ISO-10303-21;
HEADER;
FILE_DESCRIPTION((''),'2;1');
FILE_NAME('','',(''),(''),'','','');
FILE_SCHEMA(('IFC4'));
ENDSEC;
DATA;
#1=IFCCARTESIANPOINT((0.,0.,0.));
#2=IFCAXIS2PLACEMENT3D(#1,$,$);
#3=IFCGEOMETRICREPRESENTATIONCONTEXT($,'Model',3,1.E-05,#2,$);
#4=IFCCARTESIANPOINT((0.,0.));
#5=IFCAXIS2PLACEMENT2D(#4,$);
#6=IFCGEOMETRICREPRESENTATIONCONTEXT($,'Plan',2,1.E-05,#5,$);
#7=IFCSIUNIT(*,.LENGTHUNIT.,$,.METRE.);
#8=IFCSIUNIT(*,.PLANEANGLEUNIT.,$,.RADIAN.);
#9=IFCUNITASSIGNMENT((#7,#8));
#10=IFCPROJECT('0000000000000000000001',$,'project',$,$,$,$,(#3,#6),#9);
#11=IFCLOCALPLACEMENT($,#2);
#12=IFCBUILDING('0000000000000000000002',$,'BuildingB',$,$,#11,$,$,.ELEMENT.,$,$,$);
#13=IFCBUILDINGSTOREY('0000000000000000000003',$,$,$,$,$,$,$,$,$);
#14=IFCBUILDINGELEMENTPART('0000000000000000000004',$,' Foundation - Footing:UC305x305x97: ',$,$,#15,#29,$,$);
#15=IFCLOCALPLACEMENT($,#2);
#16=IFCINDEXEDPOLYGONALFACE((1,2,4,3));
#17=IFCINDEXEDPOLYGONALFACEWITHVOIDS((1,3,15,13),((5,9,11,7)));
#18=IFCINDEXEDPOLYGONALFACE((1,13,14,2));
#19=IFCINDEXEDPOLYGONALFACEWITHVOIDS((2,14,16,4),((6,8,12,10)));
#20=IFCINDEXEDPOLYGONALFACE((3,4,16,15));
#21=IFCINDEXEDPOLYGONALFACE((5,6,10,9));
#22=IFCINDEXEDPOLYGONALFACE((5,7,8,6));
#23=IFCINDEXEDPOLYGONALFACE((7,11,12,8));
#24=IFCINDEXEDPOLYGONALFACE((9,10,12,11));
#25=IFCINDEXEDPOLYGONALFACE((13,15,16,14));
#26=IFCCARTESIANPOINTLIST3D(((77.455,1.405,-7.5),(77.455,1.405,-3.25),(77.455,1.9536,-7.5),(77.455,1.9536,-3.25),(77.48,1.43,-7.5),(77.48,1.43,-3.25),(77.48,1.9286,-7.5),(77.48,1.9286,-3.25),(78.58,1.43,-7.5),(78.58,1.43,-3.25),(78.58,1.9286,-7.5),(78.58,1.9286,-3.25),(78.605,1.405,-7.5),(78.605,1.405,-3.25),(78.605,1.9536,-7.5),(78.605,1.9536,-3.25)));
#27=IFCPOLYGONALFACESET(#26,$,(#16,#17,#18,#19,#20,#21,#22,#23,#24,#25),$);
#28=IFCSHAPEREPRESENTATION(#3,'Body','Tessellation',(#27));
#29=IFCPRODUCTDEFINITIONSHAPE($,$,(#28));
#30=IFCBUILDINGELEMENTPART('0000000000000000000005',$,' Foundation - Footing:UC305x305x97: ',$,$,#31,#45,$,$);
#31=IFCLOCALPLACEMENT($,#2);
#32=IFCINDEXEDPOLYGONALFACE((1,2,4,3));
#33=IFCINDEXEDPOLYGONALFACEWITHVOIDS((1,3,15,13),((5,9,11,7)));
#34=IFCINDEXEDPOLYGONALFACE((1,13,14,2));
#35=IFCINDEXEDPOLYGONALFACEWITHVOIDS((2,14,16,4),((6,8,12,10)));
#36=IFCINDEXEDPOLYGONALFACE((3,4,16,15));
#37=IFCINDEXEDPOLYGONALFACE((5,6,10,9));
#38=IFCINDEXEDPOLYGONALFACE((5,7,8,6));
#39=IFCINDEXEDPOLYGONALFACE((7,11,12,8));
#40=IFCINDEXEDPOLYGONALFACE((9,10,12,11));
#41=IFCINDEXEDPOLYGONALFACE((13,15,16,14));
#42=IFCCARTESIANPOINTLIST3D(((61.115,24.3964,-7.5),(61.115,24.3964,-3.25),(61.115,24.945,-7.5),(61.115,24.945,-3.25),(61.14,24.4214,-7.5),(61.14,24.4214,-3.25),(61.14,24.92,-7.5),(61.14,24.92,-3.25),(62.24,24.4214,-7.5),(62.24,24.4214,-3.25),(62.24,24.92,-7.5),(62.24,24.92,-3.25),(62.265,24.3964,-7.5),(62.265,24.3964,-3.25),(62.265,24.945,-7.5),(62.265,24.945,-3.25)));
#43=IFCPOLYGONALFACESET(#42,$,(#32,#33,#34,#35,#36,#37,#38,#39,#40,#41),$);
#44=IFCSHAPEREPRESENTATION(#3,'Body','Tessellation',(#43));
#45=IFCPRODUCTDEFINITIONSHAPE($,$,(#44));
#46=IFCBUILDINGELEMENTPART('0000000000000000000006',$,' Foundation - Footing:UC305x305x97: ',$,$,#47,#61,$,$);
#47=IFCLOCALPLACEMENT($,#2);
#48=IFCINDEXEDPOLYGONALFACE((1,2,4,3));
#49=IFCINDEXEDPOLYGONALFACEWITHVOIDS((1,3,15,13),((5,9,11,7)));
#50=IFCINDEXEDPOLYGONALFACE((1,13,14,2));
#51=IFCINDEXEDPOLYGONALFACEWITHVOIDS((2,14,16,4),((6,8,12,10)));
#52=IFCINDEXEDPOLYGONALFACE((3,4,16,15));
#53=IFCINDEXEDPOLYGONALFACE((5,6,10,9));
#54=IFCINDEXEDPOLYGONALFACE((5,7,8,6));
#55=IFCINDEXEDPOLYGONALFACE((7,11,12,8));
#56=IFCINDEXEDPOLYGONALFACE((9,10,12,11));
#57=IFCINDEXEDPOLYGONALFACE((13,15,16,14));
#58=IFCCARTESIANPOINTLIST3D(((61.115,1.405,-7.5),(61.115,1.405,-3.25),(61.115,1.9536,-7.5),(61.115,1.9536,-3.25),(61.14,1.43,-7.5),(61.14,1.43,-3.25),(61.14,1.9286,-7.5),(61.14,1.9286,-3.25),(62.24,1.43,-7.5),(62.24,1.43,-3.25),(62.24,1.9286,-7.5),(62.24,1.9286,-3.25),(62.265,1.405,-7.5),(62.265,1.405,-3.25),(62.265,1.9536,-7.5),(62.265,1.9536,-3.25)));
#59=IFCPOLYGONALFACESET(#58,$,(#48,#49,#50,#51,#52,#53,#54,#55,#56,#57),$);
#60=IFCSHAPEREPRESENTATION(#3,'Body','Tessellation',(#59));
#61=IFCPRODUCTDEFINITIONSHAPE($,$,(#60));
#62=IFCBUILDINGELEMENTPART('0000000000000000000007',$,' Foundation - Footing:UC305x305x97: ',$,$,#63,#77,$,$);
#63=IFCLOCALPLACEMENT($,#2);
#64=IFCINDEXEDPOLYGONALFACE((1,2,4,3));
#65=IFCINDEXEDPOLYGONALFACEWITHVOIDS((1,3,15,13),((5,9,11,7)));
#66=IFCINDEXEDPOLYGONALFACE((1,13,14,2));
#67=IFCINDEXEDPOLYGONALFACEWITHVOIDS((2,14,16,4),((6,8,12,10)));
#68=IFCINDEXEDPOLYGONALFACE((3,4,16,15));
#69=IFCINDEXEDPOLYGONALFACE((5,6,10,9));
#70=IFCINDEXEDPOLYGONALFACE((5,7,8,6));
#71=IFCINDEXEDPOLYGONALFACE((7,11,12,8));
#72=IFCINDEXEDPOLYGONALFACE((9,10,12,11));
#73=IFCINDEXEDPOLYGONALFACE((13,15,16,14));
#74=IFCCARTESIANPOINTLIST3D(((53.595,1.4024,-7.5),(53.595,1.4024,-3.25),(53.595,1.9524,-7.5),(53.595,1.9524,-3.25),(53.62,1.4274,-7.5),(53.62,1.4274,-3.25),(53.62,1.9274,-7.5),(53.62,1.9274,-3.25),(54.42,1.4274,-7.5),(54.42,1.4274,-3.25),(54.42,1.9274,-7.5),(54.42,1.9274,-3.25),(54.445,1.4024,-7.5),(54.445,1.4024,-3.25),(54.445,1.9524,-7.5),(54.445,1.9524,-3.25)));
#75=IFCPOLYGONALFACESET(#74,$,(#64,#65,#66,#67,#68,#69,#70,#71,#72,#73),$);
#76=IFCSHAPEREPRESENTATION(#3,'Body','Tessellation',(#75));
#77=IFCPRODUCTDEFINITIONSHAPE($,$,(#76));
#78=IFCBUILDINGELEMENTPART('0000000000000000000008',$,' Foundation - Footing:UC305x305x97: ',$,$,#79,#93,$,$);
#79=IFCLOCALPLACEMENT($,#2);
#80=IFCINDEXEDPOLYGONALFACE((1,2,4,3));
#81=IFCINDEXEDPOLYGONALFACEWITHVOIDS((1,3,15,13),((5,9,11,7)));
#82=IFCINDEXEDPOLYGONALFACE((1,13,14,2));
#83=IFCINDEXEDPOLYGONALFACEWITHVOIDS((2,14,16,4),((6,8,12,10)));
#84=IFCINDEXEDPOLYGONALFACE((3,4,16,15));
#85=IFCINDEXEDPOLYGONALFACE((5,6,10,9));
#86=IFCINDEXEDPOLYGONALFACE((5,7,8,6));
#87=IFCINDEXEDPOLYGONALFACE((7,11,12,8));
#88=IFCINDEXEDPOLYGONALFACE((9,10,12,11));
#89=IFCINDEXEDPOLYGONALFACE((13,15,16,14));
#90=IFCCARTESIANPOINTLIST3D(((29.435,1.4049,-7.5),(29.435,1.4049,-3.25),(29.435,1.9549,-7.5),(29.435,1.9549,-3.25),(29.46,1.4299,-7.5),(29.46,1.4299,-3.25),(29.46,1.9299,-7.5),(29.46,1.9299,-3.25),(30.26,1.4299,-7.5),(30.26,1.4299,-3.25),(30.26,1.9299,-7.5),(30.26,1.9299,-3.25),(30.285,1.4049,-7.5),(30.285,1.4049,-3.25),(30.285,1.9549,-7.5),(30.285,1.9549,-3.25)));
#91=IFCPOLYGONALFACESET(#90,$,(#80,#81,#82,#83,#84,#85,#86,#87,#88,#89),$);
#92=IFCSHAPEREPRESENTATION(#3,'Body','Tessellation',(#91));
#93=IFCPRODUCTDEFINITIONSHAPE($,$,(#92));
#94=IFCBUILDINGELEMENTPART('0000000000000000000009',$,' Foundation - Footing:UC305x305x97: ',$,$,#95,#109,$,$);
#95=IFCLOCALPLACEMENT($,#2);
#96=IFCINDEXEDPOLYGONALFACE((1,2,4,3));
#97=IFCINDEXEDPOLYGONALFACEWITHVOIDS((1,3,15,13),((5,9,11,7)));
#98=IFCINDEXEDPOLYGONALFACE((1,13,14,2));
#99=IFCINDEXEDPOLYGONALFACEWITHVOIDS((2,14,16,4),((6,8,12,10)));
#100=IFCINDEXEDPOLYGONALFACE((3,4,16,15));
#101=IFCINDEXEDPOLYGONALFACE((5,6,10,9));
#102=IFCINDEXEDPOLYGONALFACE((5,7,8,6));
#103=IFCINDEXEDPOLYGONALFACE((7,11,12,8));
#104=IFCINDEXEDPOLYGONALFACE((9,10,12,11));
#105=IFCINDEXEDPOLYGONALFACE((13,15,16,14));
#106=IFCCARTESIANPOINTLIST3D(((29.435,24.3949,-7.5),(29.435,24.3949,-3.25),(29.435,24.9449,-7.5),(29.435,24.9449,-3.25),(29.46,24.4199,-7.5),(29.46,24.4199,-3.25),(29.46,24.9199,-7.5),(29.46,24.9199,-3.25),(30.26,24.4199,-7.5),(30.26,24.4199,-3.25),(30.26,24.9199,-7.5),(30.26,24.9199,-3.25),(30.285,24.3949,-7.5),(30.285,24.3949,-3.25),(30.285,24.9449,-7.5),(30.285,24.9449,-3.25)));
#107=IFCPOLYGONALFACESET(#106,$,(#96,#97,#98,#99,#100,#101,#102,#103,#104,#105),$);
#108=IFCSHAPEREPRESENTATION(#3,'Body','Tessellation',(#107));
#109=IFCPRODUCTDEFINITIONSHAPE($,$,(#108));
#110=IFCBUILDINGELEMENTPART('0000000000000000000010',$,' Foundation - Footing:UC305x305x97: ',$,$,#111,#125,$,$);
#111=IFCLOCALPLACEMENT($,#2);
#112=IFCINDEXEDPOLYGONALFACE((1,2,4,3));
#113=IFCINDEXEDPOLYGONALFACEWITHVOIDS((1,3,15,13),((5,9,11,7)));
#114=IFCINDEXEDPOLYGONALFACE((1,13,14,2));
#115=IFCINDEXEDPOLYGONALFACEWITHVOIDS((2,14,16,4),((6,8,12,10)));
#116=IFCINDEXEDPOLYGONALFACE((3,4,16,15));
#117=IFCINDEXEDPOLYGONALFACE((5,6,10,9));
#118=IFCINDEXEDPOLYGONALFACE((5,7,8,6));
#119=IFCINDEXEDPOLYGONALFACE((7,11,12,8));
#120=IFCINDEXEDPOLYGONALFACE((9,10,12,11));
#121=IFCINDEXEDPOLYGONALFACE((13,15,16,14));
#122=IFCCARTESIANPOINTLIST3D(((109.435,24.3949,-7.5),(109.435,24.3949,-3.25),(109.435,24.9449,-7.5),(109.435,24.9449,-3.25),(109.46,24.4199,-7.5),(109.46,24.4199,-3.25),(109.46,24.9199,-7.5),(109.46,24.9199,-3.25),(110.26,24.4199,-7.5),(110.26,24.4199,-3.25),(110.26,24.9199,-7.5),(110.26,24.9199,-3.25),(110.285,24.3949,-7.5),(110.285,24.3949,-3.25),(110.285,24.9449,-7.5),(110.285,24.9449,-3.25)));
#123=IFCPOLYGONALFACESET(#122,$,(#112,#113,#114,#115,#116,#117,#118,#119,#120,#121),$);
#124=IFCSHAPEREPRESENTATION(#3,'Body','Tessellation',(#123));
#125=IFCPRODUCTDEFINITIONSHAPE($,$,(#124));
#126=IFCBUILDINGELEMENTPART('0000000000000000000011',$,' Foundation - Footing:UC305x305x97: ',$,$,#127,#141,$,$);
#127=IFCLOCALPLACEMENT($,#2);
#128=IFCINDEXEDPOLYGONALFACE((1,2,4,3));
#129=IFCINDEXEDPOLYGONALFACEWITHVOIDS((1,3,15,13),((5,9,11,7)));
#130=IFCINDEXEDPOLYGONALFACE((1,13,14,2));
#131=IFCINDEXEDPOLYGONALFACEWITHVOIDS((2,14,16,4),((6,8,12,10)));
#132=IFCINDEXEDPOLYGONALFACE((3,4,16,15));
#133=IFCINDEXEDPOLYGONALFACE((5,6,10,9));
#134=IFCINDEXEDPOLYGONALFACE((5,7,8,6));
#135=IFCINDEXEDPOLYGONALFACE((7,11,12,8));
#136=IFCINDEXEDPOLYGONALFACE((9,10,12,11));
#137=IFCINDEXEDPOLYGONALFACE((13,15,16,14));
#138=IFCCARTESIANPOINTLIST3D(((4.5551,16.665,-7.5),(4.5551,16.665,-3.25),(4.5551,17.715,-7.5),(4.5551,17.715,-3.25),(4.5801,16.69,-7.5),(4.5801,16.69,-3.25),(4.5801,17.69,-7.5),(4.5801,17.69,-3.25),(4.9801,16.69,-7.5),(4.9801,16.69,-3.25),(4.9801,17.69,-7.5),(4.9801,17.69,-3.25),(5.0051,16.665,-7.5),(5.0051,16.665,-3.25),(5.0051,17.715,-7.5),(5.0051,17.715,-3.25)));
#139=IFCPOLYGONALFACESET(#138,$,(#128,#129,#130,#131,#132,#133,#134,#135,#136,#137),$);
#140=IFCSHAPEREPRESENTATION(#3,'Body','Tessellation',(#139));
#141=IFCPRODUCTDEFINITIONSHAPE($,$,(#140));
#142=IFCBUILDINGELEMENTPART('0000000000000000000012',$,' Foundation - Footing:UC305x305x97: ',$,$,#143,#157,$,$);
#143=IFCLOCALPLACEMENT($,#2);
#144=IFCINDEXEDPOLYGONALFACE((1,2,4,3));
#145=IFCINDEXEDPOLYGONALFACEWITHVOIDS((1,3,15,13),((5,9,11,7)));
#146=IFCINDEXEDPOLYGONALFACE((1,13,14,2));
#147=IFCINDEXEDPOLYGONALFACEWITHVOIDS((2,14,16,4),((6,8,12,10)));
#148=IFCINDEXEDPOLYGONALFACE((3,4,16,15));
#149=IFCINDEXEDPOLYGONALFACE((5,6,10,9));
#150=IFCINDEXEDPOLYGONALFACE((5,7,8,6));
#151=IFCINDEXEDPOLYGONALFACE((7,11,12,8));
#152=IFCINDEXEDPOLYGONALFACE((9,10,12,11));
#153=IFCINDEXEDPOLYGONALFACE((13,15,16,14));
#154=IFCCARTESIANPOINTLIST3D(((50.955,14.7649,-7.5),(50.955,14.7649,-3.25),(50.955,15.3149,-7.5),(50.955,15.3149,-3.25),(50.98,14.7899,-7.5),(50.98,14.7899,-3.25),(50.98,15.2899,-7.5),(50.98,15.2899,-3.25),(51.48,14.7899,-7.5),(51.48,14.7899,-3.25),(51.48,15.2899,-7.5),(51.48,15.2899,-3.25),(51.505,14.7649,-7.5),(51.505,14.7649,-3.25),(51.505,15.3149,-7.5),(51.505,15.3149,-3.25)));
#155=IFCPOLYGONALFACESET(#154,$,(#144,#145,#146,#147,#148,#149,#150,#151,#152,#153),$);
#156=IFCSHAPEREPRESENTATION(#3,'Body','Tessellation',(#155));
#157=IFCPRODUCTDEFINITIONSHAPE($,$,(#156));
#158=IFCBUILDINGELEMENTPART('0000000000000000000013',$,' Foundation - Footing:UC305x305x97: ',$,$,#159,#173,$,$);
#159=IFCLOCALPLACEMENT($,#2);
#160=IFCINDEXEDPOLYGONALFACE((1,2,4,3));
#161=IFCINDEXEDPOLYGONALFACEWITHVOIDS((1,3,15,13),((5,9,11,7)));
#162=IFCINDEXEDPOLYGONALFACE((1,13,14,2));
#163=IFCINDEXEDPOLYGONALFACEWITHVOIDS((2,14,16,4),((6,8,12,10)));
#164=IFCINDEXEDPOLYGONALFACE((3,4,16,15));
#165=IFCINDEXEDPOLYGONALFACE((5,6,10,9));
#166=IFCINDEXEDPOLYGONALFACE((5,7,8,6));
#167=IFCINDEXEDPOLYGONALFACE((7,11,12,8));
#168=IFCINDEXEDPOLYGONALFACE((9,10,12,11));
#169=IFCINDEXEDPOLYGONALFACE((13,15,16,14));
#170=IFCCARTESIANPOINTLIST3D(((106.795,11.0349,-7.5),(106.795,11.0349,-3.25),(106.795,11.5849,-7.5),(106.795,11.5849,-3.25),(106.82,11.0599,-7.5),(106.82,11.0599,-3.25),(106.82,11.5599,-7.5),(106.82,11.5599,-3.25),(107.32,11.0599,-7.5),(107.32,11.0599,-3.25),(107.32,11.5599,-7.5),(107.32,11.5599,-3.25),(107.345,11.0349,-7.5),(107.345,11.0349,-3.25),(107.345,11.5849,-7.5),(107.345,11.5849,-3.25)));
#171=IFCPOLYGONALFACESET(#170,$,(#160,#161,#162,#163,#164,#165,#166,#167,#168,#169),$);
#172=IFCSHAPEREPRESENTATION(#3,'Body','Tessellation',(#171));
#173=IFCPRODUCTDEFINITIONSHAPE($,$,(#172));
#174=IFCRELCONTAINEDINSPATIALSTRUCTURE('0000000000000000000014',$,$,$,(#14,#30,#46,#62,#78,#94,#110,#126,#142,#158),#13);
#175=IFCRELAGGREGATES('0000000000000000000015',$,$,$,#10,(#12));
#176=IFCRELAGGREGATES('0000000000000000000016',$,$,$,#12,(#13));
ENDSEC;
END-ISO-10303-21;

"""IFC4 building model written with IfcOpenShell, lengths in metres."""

from ifc_helpers import new_model, si_unit, origin, origin_2d, place, context, project, spatial, polyline, outline, extrude, element, save


model = new_model("IFC4")

# Units and contexts
model_context = context("Model", 3, precision=1e-05, world=origin())
plan_context = context("Plan", 2, precision=1e-05, world=origin_2d())
ifc_project = project(units=[si_unit("LENGTHUNIT", "METRE"), si_unit("PLANEANGLEUNIT", "RADIAN")], contexts=[model_context, plan_context])

# Building, storey
building_placement = place(None, origin())
building = spatial("IfcBuilding", under=ifc_project, at=building_placement, Name="BuildingB", CompositionType="ELEMENT")
storey = spatial("IfcBuildingStorey", under=building)

# Building element parts, openings
building_element_part_1 = element("IfcBuildingElementPart", 1, inside=storey, Name=" Foundation - Footing:UC305x305x97: ", context=model_context, shape_type="SweptSolid", body=[
    extrude(outline(polyline([(77.455, 1.405, -7.5), (78.605, 1.405, -7.5), (78.605, 1.9536, -7.5), (77.455, 1.9536, -7.5), (77.455, 1.405, -7.5)])), None, (0.0, 0.0, 1.0), 4.25),
])
element("IfcOpeningElement", 2, inside=storey, cuts=building_element_part_1, context=model_context, shape_type="SweptSolid", body=[
    extrude(outline(polyline([(77.48, 1.43, -7.5), (78.58, 1.43, -7.5), (78.58, 1.9286, -7.5), (77.48, 1.9286, -7.5), (77.48, 1.43, -7.5)])), None, (0.0, 0.0, 1.0), 4.25),
])
building_element_part_2 = element("IfcBuildingElementPart", 3, inside=storey, Name=" Foundation - Footing:UC305x305x97: ", context=model_context, shape_type="SweptSolid", body=[
    extrude(outline(polyline([(61.115, 24.3964, -7.5), (62.265, 24.3964, -7.5), (62.265, 24.945, -7.5), (61.115, 24.945, -7.5), (61.115, 24.3964, -7.5)])), None, (0.0, 0.0, 1.0), 4.25),
])
element("IfcOpeningElement", 4, inside=storey, cuts=building_element_part_2, context=model_context, shape_type="SweptSolid", body=[
    extrude(outline(polyline([(61.14, 24.4214, -7.5), (62.24, 24.4214, -7.5), (62.24, 24.92, -7.5), (61.14, 24.92, -7.5), (61.14, 24.4214, -7.5)])), None, (0.0, 0.0, 1.0), 4.25),
])
building_element_part_3 = element("IfcBuildingElementPart", 5, inside=storey, Name=" Foundation - Footing:UC305x305x97: ", context=model_context, shape_type="SweptSolid", body=[
    extrude(outline(polyline([(61.115, 1.405, -7.5), (62.265, 1.405, -7.5), (62.265, 1.9536, -7.5), (61.115, 1.9536, -7.5), (61.115, 1.405, -7.5)])), None, (0.0, 0.0, 1.0), 4.25),
])
element("IfcOpeningElement", 6, inside=storey, cuts=building_element_part_3, context=model_context, shape_type="SweptSolid", body=[
    extrude(outline(polyline([(61.14, 1.43, -7.5), (62.24, 1.43, -7.5), (62.24, 1.9286, -7.5), (61.14, 1.9286, -7.5), (61.14, 1.43, -7.5)])), None, (0.0, 0.0, 1.0), 4.25),
])
building_element_part_4 = element("IfcBuildingElementPart", 7, inside=storey, Name=" Foundation - Footing:UC305x305x97: ", context=model_context, shape_type="SweptSolid", body=[
    extrude(outline(polyline([(54.445, 1.4024, -7.5), (53.595, 1.4024, -7.5), (53.595, 1.9524, -7.5), (54.445, 1.9524, -7.5), (54.445, 1.4024, -7.5)])), None, (0.0, 0.0, 1.0), 4.25),
])
element("IfcOpeningElement", 8, inside=storey, cuts=building_element_part_4, context=model_context, shape_type="SweptSolid", body=[
    extrude(outline(polyline([(54.42, 1.4274, -7.5), (53.62, 1.4274, -7.5), (53.62, 1.9274, -7.5), (54.42, 1.9274, -7.5), (54.42, 1.4274, -7.5)])), None, (0.0, 0.0, 1.0), 4.25),
])
building_element_part_5 = element("IfcBuildingElementPart", 9, inside=storey, Name=" Foundation - Footing:UC305x305x97: ", context=model_context, shape_type="SweptSolid", body=[
    extrude(outline(polyline([(30.285, 1.4049, -7.5), (29.435, 1.4049, -7.5), (29.435, 1.9549, -7.5), (30.285, 1.9549, -7.5), (30.285, 1.4049, -7.5)])), None, (0.0, 0.0, 1.0), 4.25),
])
element("IfcOpeningElement", 10, inside=storey, cuts=building_element_part_5, context=model_context, shape_type="SweptSolid", body=[
    extrude(outline(polyline([(30.26, 1.4299, -7.5), (29.46, 1.4299, -7.5), (29.46, 1.9299, -7.5), (30.26, 1.9299, -7.5), (30.26, 1.4299, -7.5)])), None, (0.0, 0.0, 1.0), 4.25),
])
building_element_part_6 = element("IfcBuildingElementPart", 11, inside=storey, Name=" Foundation - Footing:UC305x305x97: ", context=model_context, shape_type="SweptSolid", body=[
    extrude(outline(polyline([(30.285, 24.3949, -7.5), (29.435, 24.3949, -7.5), (29.435, 24.9449, -7.5), (30.285, 24.9449, -7.5), (30.285, 24.3949, -7.5)])), None, (0.0, 0.0, 1.0), 4.25),
])
element("IfcOpeningElement", 12, inside=storey, cuts=building_element_part_6, context=model_context, shape_type="SweptSolid", body=[
    extrude(outline(polyline([(30.26, 24.4199, -7.5), (29.46, 24.4199, -7.5), (29.46, 24.9199, -7.5), (30.26, 24.9199, -7.5), (30.26, 24.4199, -7.5)])), None, (0.0, 0.0, 1.0), 4.25),
])
building_element_part_7 = element("IfcBuildingElementPart", 13, inside=storey, Name=" Foundation - Footing:UC305x305x97: ", context=model_context, shape_type="SweptSolid", body=[
    extrude(outline(polyline([(110.285, 24.3949, -7.5), (109.435, 24.3949, -7.5), (109.435, 24.9449, -7.5), (110.285, 24.9449, -7.5), (110.285, 24.3949, -7.5)])), None, (0.0, 0.0, 1.0), 4.25),
])
element("IfcOpeningElement", 14, inside=storey, cuts=building_element_part_7, context=model_context, shape_type="SweptSolid", body=[
    extrude(outline(polyline([(110.26, 24.4199, -7.5), (109.46, 24.4199, -7.5), (109.46, 24.9199, -7.5), (110.26, 24.9199, -7.5), (110.26, 24.4199, -7.5)])), None, (0.0, 0.0, 1.0), 4.25),
])
building_element_part_8 = element("IfcBuildingElementPart", 15, inside=storey, Name=" Foundation - Footing:UC305x305x97: ", context=model_context, shape_type="SweptSolid", body=[
    extrude(outline(polyline([(4.5551, 17.715, -7.5), (5.0051, 17.715, -7.5), (5.0051, 16.665, -7.5), (4.5551, 16.665, -7.5), (4.5551, 17.715, -7.5)])), None, (0.0, 0.0, 1.0), 4.25),
])
element("IfcOpeningElement", 16, inside=storey, cuts=building_element_part_8, context=model_context, shape_type="SweptSolid", body=[
    extrude(outline(polyline([(4.5801, 17.69, -7.5), (4.9801, 17.69, -7.5), (4.9801, 16.69, -7.5), (4.5801, 16.69, -7.5), (4.5801, 17.69, -7.5)])), None, (0.0, 0.0, 1.0), 4.25),
])
building_element_part_9 = element("IfcBuildingElementPart", 17, inside=storey, Name=" Foundation - Footing:UC305x305x97: ", context=model_context, shape_type="SweptSolid", body=[
    extrude(outline(polyline([(50.955, 15.3149, -7.5), (51.505, 15.3149, -7.5), (51.505, 14.7649, -7.5), (50.955, 14.7649, -7.5), (50.955, 15.3149, -7.5)])), None, (0.0, 0.0, 1.0), 4.25),
])
element("IfcOpeningElement", 18, inside=storey, cuts=building_element_part_9, context=model_context, shape_type="SweptSolid", body=[
    extrude(outline(polyline([(50.98, 15.2899, -7.5), (51.48, 15.2899, -7.5), (51.48, 14.7899, -7.5), (50.98, 14.7899, -7.5), (50.98, 15.2899, -7.5)])), None, (0.0, 0.0, 1.0), 4.25),
])
building_element_part_10 = element("IfcBuildingElementPart", 19, inside=storey, Name=" Foundation - Footing:UC305x305x97: ", context=model_context, shape_type="SweptSolid", body=[
    extrude(outline(polyline([(106.795, 11.0349, -7.5), (107.345, 11.0349, -7.5), (107.345, 11.5849, -7.5), (106.795, 11.5849, -7.5), (106.795, 11.0349, -7.5)])), None, (0.0, 0.0, 1.0), 4.25),
])
element("IfcOpeningElement", 20, inside=storey, cuts=building_element_part_10, context=model_context, shape_type="SweptSolid", body=[
    extrude(outline(polyline([(106.82, 11.0599, -7.5), (107.32, 11.0599, -7.5), (107.32, 11.5599, -7.5), (106.82, 11.5599, -7.5), (106.82, 11.0599, -7.5)])), None, (0.0, 0.0, 1.0), 4.25),
])

save(model, "model.ifc")
